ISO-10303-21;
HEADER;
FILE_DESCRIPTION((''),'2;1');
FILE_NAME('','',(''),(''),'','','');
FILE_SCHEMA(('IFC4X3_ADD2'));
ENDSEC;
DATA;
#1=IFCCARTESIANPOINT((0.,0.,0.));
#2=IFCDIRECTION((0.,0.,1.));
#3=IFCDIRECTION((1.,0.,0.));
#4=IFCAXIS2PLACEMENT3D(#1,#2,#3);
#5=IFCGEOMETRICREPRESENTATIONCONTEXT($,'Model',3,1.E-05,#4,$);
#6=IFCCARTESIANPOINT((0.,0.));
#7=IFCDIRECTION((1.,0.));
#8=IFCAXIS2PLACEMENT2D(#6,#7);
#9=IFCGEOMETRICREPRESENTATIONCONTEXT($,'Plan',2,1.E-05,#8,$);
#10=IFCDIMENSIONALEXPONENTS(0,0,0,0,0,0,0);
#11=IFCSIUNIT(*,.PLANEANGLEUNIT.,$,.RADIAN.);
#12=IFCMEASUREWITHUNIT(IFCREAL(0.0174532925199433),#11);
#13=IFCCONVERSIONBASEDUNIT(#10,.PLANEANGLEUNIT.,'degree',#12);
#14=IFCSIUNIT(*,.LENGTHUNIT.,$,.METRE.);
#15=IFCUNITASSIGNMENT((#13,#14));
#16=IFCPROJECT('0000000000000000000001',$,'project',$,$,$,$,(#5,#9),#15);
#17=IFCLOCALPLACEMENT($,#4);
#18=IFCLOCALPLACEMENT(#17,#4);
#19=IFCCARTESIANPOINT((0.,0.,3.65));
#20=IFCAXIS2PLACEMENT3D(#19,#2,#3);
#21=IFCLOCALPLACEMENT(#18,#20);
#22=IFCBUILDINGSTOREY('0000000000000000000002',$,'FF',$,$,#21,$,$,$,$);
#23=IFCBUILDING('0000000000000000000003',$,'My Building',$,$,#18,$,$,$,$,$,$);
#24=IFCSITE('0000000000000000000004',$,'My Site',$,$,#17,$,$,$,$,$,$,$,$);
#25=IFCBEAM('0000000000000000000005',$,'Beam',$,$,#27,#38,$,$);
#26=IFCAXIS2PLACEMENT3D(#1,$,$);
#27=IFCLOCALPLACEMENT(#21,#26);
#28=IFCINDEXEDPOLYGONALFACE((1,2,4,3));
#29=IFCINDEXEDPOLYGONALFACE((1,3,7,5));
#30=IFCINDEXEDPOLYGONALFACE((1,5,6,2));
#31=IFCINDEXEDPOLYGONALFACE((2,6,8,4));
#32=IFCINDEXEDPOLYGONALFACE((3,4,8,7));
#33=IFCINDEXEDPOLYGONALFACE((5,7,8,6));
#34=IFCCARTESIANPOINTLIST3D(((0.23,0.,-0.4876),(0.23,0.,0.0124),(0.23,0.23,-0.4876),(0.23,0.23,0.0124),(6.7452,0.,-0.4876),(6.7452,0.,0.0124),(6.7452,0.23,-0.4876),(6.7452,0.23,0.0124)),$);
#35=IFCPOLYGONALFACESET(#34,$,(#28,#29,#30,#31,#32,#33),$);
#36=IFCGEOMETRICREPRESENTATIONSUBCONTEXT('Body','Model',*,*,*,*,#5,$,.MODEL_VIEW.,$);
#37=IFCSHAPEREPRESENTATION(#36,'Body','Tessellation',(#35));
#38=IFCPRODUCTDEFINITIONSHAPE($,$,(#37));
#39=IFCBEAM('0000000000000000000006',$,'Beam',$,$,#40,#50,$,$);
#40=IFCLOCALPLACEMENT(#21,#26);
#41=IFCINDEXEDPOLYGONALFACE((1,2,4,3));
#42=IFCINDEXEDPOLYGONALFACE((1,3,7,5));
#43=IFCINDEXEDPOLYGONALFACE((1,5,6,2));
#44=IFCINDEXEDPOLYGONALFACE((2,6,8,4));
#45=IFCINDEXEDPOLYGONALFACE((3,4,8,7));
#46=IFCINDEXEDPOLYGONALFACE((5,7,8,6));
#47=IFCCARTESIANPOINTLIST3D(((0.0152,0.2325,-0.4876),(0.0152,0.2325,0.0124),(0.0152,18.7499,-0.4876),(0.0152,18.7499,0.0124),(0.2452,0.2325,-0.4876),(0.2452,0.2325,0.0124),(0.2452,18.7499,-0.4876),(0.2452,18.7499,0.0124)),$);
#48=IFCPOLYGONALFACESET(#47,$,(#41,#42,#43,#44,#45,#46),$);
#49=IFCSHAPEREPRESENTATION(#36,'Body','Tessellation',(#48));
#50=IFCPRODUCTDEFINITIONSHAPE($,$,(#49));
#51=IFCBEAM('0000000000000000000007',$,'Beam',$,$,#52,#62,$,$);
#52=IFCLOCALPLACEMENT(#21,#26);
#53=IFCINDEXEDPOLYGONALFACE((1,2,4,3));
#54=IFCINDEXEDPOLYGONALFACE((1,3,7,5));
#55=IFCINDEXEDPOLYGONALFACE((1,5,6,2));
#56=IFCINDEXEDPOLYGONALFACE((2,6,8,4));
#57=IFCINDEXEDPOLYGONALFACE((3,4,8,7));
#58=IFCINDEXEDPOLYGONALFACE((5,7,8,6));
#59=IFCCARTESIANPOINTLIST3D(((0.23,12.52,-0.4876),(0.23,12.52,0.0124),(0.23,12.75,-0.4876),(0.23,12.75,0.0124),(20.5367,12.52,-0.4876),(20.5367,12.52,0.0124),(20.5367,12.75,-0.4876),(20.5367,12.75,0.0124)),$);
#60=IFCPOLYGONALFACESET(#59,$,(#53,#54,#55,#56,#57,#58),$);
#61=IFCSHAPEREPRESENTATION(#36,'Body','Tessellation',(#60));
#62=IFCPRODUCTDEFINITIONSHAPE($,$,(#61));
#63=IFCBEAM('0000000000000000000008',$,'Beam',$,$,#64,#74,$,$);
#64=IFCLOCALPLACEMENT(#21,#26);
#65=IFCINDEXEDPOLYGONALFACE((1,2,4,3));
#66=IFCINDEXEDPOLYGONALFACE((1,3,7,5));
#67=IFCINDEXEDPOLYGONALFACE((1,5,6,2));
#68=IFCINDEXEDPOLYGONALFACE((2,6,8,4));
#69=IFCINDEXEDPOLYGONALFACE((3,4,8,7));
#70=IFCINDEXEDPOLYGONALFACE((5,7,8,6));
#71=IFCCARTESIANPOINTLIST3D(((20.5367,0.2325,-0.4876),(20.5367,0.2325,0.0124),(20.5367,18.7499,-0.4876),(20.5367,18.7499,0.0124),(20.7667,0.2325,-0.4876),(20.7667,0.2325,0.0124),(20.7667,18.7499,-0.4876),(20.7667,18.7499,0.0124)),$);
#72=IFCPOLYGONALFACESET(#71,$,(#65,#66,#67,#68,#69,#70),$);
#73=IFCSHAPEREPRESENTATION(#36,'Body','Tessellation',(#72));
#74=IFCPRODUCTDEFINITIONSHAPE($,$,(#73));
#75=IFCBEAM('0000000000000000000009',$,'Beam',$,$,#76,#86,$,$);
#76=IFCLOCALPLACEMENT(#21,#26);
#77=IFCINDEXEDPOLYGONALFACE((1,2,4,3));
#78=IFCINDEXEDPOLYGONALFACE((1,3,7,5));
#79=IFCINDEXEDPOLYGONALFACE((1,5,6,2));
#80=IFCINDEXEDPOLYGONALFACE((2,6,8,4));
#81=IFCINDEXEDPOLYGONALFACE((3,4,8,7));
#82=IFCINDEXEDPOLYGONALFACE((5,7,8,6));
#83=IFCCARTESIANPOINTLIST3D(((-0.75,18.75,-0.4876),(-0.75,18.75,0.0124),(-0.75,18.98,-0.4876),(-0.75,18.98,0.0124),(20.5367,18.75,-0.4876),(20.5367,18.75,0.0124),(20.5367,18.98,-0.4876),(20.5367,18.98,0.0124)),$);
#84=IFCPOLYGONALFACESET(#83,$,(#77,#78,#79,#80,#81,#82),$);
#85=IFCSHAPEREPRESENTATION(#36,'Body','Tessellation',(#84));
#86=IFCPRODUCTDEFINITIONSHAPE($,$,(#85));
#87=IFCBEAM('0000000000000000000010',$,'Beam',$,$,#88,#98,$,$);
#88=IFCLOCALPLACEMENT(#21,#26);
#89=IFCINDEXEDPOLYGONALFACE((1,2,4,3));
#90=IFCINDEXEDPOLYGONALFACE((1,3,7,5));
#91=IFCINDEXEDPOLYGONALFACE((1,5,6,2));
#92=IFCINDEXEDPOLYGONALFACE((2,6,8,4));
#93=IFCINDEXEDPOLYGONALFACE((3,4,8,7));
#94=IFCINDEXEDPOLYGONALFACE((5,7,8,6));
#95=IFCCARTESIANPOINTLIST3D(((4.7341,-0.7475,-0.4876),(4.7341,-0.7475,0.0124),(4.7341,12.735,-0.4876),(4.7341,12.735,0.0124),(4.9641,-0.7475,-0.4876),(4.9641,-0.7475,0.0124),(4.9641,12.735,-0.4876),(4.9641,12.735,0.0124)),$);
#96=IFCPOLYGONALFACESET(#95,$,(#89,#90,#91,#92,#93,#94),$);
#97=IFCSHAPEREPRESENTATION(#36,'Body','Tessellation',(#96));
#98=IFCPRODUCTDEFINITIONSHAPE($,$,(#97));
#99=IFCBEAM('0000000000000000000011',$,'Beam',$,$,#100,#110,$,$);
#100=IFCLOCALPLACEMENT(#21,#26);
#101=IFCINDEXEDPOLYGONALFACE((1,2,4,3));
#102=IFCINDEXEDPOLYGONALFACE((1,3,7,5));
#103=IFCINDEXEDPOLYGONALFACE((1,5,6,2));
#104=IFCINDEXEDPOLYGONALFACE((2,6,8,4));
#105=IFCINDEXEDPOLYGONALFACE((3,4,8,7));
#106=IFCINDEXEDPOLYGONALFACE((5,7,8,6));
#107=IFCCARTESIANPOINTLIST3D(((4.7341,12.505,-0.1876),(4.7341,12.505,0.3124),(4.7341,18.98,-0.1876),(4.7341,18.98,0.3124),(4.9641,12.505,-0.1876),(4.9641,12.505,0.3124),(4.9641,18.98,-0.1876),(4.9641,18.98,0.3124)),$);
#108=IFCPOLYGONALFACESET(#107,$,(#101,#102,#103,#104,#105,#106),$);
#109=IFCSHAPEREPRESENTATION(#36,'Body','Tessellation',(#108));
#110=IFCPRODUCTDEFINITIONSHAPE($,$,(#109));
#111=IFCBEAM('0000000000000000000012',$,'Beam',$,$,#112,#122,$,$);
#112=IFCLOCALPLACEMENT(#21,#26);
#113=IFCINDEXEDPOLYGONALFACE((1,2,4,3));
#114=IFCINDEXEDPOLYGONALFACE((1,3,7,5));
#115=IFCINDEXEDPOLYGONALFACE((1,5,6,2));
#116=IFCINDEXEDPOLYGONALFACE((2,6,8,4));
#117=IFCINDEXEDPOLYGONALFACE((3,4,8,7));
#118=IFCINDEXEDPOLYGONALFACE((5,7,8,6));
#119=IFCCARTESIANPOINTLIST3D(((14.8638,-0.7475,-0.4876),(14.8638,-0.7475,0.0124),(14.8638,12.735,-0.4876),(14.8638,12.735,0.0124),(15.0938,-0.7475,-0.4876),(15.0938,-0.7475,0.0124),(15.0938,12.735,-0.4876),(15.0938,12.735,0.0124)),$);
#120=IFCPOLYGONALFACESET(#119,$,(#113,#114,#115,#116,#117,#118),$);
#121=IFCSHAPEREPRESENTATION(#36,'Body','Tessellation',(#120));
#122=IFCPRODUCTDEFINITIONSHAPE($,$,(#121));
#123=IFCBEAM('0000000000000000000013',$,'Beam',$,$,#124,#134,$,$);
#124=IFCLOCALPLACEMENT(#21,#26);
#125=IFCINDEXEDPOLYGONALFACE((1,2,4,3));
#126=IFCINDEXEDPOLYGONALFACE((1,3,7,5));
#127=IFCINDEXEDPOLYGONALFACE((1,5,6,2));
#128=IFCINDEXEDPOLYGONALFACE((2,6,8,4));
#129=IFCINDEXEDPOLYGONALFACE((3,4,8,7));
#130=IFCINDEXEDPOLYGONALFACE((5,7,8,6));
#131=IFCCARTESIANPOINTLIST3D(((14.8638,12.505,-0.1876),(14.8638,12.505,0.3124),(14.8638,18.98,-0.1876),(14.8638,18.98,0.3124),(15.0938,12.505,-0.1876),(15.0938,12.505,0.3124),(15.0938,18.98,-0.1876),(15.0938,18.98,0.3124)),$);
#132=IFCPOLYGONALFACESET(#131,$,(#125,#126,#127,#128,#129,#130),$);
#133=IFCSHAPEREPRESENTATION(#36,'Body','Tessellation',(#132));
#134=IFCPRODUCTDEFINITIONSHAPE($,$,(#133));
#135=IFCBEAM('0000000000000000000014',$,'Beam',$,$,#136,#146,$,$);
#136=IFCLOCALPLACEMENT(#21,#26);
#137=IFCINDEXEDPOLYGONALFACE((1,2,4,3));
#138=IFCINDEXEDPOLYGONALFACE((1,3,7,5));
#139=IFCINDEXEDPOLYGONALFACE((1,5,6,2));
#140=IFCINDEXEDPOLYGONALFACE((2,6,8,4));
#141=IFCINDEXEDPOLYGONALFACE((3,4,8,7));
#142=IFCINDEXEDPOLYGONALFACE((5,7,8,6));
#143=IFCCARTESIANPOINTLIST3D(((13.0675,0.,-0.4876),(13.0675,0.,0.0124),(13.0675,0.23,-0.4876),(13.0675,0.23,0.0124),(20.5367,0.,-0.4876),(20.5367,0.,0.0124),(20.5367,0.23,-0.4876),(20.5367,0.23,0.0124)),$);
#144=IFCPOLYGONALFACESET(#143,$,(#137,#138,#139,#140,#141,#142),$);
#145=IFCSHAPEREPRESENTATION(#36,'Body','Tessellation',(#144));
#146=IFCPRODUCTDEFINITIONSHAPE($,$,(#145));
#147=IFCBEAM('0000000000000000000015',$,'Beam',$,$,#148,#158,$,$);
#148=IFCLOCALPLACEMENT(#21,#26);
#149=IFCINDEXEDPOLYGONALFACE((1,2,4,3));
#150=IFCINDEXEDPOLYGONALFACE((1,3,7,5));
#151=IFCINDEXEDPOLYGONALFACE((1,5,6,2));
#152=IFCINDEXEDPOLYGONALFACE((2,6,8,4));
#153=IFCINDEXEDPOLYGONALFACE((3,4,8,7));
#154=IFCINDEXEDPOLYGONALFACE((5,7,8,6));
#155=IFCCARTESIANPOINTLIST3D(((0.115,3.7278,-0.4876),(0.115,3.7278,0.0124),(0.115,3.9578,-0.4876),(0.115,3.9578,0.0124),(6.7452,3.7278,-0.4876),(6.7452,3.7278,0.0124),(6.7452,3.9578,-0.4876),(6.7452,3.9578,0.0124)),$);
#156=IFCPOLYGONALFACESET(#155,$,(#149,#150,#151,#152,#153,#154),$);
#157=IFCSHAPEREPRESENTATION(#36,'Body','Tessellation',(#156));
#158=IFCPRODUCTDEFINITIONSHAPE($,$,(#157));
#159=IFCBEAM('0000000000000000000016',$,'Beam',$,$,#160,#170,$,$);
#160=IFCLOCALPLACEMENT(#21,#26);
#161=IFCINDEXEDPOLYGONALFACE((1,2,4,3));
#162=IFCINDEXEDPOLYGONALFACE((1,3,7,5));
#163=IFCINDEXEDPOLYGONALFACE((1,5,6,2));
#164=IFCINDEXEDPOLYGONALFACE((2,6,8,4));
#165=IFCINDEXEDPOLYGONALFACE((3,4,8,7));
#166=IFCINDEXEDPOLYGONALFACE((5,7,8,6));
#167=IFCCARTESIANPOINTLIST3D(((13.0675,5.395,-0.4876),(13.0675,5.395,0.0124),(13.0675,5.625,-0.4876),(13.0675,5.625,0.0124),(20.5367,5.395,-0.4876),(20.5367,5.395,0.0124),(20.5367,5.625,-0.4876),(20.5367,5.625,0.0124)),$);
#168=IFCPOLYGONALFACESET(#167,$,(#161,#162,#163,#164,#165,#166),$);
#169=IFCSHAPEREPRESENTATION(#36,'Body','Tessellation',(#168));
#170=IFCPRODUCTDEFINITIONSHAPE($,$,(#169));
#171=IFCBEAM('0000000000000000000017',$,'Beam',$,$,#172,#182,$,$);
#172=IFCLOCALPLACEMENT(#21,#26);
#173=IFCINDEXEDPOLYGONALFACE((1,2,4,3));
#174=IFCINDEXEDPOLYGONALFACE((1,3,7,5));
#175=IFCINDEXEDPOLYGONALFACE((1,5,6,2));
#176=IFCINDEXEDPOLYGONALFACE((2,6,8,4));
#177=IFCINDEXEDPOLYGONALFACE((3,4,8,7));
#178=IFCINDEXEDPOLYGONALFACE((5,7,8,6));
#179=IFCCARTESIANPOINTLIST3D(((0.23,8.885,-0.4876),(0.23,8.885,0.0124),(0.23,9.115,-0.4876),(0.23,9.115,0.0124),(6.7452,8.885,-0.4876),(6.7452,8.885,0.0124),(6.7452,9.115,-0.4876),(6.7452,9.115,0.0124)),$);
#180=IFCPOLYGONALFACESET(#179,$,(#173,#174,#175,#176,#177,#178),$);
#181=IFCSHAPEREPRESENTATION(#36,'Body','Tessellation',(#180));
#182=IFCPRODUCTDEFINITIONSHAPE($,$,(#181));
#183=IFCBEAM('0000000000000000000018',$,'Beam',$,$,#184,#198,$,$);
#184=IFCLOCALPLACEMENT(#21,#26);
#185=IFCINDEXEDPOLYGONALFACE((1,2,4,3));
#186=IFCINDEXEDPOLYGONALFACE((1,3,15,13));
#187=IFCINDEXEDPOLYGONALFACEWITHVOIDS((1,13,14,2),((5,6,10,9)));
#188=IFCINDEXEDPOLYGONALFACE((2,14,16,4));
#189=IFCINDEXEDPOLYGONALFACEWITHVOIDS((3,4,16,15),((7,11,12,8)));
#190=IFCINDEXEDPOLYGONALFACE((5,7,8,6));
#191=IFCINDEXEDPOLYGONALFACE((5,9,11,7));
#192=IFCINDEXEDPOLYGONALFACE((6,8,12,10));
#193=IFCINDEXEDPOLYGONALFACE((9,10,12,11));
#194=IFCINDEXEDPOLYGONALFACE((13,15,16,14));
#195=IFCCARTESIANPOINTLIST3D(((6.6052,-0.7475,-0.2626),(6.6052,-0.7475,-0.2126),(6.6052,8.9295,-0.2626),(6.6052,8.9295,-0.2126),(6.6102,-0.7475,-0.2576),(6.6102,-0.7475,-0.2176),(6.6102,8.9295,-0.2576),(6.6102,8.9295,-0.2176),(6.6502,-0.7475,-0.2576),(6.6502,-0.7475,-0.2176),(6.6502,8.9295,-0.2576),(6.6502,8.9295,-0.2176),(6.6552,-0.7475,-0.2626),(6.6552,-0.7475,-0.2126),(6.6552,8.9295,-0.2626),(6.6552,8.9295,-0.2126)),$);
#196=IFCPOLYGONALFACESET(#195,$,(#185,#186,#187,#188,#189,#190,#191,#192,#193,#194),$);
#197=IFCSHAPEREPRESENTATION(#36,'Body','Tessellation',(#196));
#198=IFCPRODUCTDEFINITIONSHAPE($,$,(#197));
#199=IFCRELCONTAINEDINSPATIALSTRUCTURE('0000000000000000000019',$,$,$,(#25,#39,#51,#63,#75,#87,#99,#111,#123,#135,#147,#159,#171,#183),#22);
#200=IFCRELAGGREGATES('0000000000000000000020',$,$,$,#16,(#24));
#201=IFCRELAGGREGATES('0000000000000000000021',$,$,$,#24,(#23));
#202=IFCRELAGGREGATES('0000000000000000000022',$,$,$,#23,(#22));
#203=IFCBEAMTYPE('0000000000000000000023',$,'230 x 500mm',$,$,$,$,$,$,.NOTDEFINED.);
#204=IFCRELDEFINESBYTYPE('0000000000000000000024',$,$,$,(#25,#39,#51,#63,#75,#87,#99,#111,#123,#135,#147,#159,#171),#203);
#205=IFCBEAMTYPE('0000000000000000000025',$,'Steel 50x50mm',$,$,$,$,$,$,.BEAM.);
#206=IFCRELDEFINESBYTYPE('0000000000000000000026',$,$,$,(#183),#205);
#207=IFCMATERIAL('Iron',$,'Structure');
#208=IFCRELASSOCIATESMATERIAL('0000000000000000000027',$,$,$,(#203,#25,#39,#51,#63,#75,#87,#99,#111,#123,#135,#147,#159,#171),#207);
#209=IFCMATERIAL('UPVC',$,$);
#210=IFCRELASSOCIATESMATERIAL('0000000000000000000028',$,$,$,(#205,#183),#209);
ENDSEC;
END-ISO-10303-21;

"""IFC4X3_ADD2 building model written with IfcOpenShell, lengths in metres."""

from ifc_helpers import new_model, entity, si_unit, converted_unit, frame, origin_with_axes, origin_2d_with_axis, place, context, subcontext, project, spatial, rectangle, hollow_rectangle, extrude, material, material_profile, profile_set, profile_usage, type_object, element, save


model = new_model("IFC4X3_ADD2")

# Units and contexts
model_context = context("Model", 3, precision=1e-05, world=origin_with_axes())
plan_context = context("Plan", 2, precision=1e-05, world=origin_2d_with_axis())
body_context = subcontext(model_context, "Body", "Model", "MODEL_VIEW")
ifc_project = project(units=[converted_unit("PLANEANGLEUNIT", "degree", entity("IfcReal", 0.0174532925199433), si_unit("PLANEANGLEUNIT", "RADIAN"), dimensions=[0, 0, 0, 0, 0, 0, 0]), si_unit("LENGTHUNIT", "METRE")], contexts=[model_context, plan_context])

# Site, building, storey
site_placement = place(None, origin_with_axes())
site = spatial("IfcSite", under=ifc_project, at=site_placement, Name="My Site")
building_placement = place(site_placement, origin_with_axes())
building = spatial("IfcBuilding", under=site, at=building_placement, Name="My Building")
storey_placement = place(building_placement, frame((0.0, 0.0, 3.65), z_axis=(0.0, 0.0, 1.0), x_axis=(1.0, 0.0, 0.0)))
storey = spatial("IfcBuildingStorey", under=building, at=storey_placement, Name="FF")

# Beams
ifc_material_1 = material(Name="Iron", Category="Structure")
ifc_material_profile_1 = material_profile(ifc_material_1, rectangle(XDim=0.23, YDim=0.5))
ifc_profile_set_1 = profile_set([ifc_material_profile_1])
ifc_profile_usage_1 = profile_usage(ifc_profile_set_1)
beam_type_1 = type_object("IfcBeamType", Name="230 x 500mm", PredefinedType="NOTDEFINED", material=ifc_profile_set_1)
beam_1_placement = place(storey_placement, frame((0.23, 0.115, -0.2376), z_axis=(1.0, 0.0, 0.0), x_axis=(0.0, 1.0, 0.0)))
element("IfcBeam", 1, at=beam_1_placement, inside=storey, type_object=beam_type_1, material=ifc_profile_usage_1, Name="Beam", context=body_context, shape_type="SweptSolid", body=[
    extrude(rectangle(XDim=0.23, YDim=0.5), origin_with_axes(), (0.0, 0.0, 1.0), 6.5152),
])
ifc_profile_usage_2 = profile_usage(ifc_profile_set_1)
beam_2_placement = place(storey_placement, frame((0.1302, 18.7499, -0.2376), z_axis=(0.0, -1.0, 0.0), x_axis=(1.0, 0.0, 0.0)))
element("IfcBeam", 2, at=beam_2_placement, inside=storey, type_object=beam_type_1, material=ifc_profile_usage_2, Name="Beam", context=body_context, shape_type="SweptSolid", body=[
    extrude(rectangle(XDim=0.23, YDim=0.5), origin_with_axes(), (0.0, 0.0, 1.0), 18.5174),
])
ifc_profile_usage_3 = profile_usage(ifc_profile_set_1)
beam_3_placement = place(storey_placement, frame((0.23, 12.635, -0.2376), z_axis=(1.0, -0.000001, 0.0), x_axis=(0.000001, 1.0, 0.0)))
element("IfcBeam", 3, at=beam_3_placement, inside=storey, type_object=beam_type_1, material=ifc_profile_usage_3, Name="Beam", context=body_context, shape_type="SweptSolid", body=[
    extrude(rectangle(XDim=0.23, YDim=0.5), origin_with_axes(), (0.0, 0.0, 1.0), 20.3067),
])
ifc_profile_usage_4 = profile_usage(ifc_profile_set_1)
beam_4_placement = place(storey_placement, frame((20.6517, 18.7499, -0.2376), z_axis=(0.0, -1.0, 0.0), x_axis=(1.0, 0.0, 0.0)))
element("IfcBeam", 4, at=beam_4_placement, inside=storey, type_object=beam_type_1, material=ifc_profile_usage_4, Name="Beam", context=body_context, shape_type="SweptSolid", body=[
    extrude(rectangle(XDim=0.23, YDim=0.5), origin_with_axes(), (0.0, 0.0, 1.0), 18.5174),
])
ifc_profile_usage_5 = profile_usage(ifc_profile_set_1)
beam_5_placement = place(storey_placement, frame((-0.75, 18.865, -0.2376), z_axis=(1.0, 0.0, 0.0), x_axis=(0.0, 1.0, 0.0)))
element("IfcBeam", 5, at=beam_5_placement, inside=storey, type_object=beam_type_1, material=ifc_profile_usage_5, Name="Beam", context=body_context, shape_type="SweptSolid", body=[
    extrude(rectangle(XDim=0.23, YDim=0.5), origin_with_axes(), (0.0, 0.0, 1.0), 21.2867),
])
ifc_profile_usage_6 = profile_usage(ifc_profile_set_1)
beam_6_placement = place(storey_placement, frame((4.8491, 12.735, -0.2376), z_axis=(0.0, -1.0, 0.0), x_axis=(1.0, 0.0, 0.0)))
element("IfcBeam", 6, at=beam_6_placement, inside=storey, type_object=beam_type_1, material=ifc_profile_usage_6, Name="Beam", context=body_context, shape_type="SweptSolid", body=[
    extrude(rectangle(XDim=0.23, YDim=0.5), origin_with_axes(), (0.0, 0.0, 1.0), 13.4825),
])
ifc_profile_usage_7 = profile_usage(ifc_profile_set_1)
beam_7_placement = place(storey_placement, frame((4.8491, 18.98, 0.0624), z_axis=(0.0, -1.0, 0.0), x_axis=(1.0, 0.0, 0.0)))
element("IfcBeam", 7, at=beam_7_placement, inside=storey, type_object=beam_type_1, material=ifc_profile_usage_7, Name="Beam", context=body_context, shape_type="SweptSolid", body=[
    extrude(rectangle(XDim=0.23, YDim=0.5), origin_with_axes(), (0.0, 0.0, 1.0), 6.475),
])
ifc_profile_usage_8 = profile_usage(ifc_profile_set_1)
beam_8_placement = place(storey_placement, frame((14.9788, 12.735, -0.2376), z_axis=(0.0, -1.0, 0.0), x_axis=(1.0, 0.0, 0.0)))
element("IfcBeam", 8, at=beam_8_placement, inside=storey, type_object=beam_type_1, material=ifc_profile_usage_8, Name="Beam", context=body_context, shape_type="SweptSolid", body=[
    extrude(rectangle(XDim=0.23, YDim=0.5), origin_with_axes(), (0.0, 0.0, 1.0), 13.4825),
])
ifc_profile_usage_9 = profile_usage(ifc_profile_set_1)
beam_9_placement = place(storey_placement, frame((14.9788, 18.98, 0.0624), z_axis=(0.0, -1.0, 0.0), x_axis=(1.0, 0.0, 0.0)))
element("IfcBeam", 9, at=beam_9_placement, inside=storey, type_object=beam_type_1, material=ifc_profile_usage_9, Name="Beam", context=body_context, shape_type="SweptSolid", body=[
    extrude(rectangle(XDim=0.23, YDim=0.5), origin_with_axes(), (0.0, 0.0, 1.0), 6.475),
])
ifc_profile_usage_10 = profile_usage(ifc_profile_set_1)
beam_10_placement = place(storey_placement, frame((13.0675, 0.115, -0.2376), z_axis=(1.0, 0.0, 0.0), x_axis=(0.0, 1.0, 0.0)))
element("IfcBeam", 10, at=beam_10_placement, inside=storey, type_object=beam_type_1, material=ifc_profile_usage_10, Name="Beam", context=body_context, shape_type="SweptSolid", body=[
    extrude(rectangle(XDim=0.23, YDim=0.5), origin_with_axes(), (0.0, 0.0, 1.0), 7.4693),
])
ifc_profile_usage_11 = profile_usage(ifc_profile_set_1)
beam_11_placement = place(storey_placement, frame((0.115, 3.8428, -0.2376), z_axis=(1.0, 0.0, 0.0), x_axis=(0.0, 1.0, 0.0)))
element("IfcBeam", 11, at=beam_11_placement, inside=storey, type_object=beam_type_1, material=ifc_profile_usage_11, Name="Beam", context=body_context, shape_type="SweptSolid", body=[
    extrude(rectangle(XDim=0.23, YDim=0.5), origin_with_axes(), (0.0, 0.0, 1.0), 6.6302),
])
ifc_profile_usage_12 = profile_usage(ifc_profile_set_1)
beam_12_placement = place(storey_placement, frame((13.0675, 5.51, -0.2376), z_axis=(1.0, 0.0, 0.0), x_axis=(0.0, 1.0, 0.0)))
element("IfcBeam", 12, at=beam_12_placement, inside=storey, type_object=beam_type_1, material=ifc_profile_usage_12, Name="Beam", context=body_context, shape_type="SweptSolid", body=[
    extrude(rectangle(XDim=0.23, YDim=0.5), origin_with_axes(), (0.0, 0.0, 1.0), 7.4693),
])
ifc_profile_usage_13 = profile_usage(ifc_profile_set_1)
beam_13_placement = place(storey_placement, frame((0.23, 9.0, -0.2376), z_axis=(1.0, 0.0, 0.0), x_axis=(0.0, 1.0, 0.0)))
element("IfcBeam", 13, at=beam_13_placement, inside=storey, type_object=beam_type_1, material=ifc_profile_usage_13, Name="Beam", context=body_context, shape_type="SweptSolid", body=[
    extrude(rectangle(XDim=0.23, YDim=0.5), origin_with_axes(), (0.0, 0.0, 1.0), 6.5152),
])
ifc_material_2 = material(Name="UPVC")
ifc_material_profile_2 = material_profile(ifc_material_2, hollow_rectangle(XDim=0.05, YDim=0.05, WallThickness=0.005))
ifc_material_profile_3 = material_profile(ifc_material_2, hollow_rectangle(XDim=0.05, YDim=0.05, WallThickness=0.005))
ifc_profile_set_2 = profile_set([ifc_material_profile_2, ifc_material_profile_3])
ifc_profile_usage_14 = profile_usage(ifc_profile_set_2)
beam_type_2 = type_object("IfcBeamType", Name="Steel 50x50mm", PredefinedType="BEAM", material=ifc_profile_set_2)
beam_14_placement = place(storey_placement, frame((6.6302, -0.7475, -0.2376), z_axis=(0.0, 1.0, 0.0), x_axis=(-1.0, 0.0, 0.0)))
element("IfcBeam", 14, at=beam_14_placement, inside=storey, type_object=beam_type_2, material=ifc_profile_usage_14, Name="Beam", context=body_context, shape_type="SweptSolid", body=[
    extrude(hollow_rectangle(XDim=0.05, YDim=0.05, WallThickness=0.005), origin_with_axes(), (0.0, 0.0, 1.0), 9.677),
])

save(model, "model.ifc")
